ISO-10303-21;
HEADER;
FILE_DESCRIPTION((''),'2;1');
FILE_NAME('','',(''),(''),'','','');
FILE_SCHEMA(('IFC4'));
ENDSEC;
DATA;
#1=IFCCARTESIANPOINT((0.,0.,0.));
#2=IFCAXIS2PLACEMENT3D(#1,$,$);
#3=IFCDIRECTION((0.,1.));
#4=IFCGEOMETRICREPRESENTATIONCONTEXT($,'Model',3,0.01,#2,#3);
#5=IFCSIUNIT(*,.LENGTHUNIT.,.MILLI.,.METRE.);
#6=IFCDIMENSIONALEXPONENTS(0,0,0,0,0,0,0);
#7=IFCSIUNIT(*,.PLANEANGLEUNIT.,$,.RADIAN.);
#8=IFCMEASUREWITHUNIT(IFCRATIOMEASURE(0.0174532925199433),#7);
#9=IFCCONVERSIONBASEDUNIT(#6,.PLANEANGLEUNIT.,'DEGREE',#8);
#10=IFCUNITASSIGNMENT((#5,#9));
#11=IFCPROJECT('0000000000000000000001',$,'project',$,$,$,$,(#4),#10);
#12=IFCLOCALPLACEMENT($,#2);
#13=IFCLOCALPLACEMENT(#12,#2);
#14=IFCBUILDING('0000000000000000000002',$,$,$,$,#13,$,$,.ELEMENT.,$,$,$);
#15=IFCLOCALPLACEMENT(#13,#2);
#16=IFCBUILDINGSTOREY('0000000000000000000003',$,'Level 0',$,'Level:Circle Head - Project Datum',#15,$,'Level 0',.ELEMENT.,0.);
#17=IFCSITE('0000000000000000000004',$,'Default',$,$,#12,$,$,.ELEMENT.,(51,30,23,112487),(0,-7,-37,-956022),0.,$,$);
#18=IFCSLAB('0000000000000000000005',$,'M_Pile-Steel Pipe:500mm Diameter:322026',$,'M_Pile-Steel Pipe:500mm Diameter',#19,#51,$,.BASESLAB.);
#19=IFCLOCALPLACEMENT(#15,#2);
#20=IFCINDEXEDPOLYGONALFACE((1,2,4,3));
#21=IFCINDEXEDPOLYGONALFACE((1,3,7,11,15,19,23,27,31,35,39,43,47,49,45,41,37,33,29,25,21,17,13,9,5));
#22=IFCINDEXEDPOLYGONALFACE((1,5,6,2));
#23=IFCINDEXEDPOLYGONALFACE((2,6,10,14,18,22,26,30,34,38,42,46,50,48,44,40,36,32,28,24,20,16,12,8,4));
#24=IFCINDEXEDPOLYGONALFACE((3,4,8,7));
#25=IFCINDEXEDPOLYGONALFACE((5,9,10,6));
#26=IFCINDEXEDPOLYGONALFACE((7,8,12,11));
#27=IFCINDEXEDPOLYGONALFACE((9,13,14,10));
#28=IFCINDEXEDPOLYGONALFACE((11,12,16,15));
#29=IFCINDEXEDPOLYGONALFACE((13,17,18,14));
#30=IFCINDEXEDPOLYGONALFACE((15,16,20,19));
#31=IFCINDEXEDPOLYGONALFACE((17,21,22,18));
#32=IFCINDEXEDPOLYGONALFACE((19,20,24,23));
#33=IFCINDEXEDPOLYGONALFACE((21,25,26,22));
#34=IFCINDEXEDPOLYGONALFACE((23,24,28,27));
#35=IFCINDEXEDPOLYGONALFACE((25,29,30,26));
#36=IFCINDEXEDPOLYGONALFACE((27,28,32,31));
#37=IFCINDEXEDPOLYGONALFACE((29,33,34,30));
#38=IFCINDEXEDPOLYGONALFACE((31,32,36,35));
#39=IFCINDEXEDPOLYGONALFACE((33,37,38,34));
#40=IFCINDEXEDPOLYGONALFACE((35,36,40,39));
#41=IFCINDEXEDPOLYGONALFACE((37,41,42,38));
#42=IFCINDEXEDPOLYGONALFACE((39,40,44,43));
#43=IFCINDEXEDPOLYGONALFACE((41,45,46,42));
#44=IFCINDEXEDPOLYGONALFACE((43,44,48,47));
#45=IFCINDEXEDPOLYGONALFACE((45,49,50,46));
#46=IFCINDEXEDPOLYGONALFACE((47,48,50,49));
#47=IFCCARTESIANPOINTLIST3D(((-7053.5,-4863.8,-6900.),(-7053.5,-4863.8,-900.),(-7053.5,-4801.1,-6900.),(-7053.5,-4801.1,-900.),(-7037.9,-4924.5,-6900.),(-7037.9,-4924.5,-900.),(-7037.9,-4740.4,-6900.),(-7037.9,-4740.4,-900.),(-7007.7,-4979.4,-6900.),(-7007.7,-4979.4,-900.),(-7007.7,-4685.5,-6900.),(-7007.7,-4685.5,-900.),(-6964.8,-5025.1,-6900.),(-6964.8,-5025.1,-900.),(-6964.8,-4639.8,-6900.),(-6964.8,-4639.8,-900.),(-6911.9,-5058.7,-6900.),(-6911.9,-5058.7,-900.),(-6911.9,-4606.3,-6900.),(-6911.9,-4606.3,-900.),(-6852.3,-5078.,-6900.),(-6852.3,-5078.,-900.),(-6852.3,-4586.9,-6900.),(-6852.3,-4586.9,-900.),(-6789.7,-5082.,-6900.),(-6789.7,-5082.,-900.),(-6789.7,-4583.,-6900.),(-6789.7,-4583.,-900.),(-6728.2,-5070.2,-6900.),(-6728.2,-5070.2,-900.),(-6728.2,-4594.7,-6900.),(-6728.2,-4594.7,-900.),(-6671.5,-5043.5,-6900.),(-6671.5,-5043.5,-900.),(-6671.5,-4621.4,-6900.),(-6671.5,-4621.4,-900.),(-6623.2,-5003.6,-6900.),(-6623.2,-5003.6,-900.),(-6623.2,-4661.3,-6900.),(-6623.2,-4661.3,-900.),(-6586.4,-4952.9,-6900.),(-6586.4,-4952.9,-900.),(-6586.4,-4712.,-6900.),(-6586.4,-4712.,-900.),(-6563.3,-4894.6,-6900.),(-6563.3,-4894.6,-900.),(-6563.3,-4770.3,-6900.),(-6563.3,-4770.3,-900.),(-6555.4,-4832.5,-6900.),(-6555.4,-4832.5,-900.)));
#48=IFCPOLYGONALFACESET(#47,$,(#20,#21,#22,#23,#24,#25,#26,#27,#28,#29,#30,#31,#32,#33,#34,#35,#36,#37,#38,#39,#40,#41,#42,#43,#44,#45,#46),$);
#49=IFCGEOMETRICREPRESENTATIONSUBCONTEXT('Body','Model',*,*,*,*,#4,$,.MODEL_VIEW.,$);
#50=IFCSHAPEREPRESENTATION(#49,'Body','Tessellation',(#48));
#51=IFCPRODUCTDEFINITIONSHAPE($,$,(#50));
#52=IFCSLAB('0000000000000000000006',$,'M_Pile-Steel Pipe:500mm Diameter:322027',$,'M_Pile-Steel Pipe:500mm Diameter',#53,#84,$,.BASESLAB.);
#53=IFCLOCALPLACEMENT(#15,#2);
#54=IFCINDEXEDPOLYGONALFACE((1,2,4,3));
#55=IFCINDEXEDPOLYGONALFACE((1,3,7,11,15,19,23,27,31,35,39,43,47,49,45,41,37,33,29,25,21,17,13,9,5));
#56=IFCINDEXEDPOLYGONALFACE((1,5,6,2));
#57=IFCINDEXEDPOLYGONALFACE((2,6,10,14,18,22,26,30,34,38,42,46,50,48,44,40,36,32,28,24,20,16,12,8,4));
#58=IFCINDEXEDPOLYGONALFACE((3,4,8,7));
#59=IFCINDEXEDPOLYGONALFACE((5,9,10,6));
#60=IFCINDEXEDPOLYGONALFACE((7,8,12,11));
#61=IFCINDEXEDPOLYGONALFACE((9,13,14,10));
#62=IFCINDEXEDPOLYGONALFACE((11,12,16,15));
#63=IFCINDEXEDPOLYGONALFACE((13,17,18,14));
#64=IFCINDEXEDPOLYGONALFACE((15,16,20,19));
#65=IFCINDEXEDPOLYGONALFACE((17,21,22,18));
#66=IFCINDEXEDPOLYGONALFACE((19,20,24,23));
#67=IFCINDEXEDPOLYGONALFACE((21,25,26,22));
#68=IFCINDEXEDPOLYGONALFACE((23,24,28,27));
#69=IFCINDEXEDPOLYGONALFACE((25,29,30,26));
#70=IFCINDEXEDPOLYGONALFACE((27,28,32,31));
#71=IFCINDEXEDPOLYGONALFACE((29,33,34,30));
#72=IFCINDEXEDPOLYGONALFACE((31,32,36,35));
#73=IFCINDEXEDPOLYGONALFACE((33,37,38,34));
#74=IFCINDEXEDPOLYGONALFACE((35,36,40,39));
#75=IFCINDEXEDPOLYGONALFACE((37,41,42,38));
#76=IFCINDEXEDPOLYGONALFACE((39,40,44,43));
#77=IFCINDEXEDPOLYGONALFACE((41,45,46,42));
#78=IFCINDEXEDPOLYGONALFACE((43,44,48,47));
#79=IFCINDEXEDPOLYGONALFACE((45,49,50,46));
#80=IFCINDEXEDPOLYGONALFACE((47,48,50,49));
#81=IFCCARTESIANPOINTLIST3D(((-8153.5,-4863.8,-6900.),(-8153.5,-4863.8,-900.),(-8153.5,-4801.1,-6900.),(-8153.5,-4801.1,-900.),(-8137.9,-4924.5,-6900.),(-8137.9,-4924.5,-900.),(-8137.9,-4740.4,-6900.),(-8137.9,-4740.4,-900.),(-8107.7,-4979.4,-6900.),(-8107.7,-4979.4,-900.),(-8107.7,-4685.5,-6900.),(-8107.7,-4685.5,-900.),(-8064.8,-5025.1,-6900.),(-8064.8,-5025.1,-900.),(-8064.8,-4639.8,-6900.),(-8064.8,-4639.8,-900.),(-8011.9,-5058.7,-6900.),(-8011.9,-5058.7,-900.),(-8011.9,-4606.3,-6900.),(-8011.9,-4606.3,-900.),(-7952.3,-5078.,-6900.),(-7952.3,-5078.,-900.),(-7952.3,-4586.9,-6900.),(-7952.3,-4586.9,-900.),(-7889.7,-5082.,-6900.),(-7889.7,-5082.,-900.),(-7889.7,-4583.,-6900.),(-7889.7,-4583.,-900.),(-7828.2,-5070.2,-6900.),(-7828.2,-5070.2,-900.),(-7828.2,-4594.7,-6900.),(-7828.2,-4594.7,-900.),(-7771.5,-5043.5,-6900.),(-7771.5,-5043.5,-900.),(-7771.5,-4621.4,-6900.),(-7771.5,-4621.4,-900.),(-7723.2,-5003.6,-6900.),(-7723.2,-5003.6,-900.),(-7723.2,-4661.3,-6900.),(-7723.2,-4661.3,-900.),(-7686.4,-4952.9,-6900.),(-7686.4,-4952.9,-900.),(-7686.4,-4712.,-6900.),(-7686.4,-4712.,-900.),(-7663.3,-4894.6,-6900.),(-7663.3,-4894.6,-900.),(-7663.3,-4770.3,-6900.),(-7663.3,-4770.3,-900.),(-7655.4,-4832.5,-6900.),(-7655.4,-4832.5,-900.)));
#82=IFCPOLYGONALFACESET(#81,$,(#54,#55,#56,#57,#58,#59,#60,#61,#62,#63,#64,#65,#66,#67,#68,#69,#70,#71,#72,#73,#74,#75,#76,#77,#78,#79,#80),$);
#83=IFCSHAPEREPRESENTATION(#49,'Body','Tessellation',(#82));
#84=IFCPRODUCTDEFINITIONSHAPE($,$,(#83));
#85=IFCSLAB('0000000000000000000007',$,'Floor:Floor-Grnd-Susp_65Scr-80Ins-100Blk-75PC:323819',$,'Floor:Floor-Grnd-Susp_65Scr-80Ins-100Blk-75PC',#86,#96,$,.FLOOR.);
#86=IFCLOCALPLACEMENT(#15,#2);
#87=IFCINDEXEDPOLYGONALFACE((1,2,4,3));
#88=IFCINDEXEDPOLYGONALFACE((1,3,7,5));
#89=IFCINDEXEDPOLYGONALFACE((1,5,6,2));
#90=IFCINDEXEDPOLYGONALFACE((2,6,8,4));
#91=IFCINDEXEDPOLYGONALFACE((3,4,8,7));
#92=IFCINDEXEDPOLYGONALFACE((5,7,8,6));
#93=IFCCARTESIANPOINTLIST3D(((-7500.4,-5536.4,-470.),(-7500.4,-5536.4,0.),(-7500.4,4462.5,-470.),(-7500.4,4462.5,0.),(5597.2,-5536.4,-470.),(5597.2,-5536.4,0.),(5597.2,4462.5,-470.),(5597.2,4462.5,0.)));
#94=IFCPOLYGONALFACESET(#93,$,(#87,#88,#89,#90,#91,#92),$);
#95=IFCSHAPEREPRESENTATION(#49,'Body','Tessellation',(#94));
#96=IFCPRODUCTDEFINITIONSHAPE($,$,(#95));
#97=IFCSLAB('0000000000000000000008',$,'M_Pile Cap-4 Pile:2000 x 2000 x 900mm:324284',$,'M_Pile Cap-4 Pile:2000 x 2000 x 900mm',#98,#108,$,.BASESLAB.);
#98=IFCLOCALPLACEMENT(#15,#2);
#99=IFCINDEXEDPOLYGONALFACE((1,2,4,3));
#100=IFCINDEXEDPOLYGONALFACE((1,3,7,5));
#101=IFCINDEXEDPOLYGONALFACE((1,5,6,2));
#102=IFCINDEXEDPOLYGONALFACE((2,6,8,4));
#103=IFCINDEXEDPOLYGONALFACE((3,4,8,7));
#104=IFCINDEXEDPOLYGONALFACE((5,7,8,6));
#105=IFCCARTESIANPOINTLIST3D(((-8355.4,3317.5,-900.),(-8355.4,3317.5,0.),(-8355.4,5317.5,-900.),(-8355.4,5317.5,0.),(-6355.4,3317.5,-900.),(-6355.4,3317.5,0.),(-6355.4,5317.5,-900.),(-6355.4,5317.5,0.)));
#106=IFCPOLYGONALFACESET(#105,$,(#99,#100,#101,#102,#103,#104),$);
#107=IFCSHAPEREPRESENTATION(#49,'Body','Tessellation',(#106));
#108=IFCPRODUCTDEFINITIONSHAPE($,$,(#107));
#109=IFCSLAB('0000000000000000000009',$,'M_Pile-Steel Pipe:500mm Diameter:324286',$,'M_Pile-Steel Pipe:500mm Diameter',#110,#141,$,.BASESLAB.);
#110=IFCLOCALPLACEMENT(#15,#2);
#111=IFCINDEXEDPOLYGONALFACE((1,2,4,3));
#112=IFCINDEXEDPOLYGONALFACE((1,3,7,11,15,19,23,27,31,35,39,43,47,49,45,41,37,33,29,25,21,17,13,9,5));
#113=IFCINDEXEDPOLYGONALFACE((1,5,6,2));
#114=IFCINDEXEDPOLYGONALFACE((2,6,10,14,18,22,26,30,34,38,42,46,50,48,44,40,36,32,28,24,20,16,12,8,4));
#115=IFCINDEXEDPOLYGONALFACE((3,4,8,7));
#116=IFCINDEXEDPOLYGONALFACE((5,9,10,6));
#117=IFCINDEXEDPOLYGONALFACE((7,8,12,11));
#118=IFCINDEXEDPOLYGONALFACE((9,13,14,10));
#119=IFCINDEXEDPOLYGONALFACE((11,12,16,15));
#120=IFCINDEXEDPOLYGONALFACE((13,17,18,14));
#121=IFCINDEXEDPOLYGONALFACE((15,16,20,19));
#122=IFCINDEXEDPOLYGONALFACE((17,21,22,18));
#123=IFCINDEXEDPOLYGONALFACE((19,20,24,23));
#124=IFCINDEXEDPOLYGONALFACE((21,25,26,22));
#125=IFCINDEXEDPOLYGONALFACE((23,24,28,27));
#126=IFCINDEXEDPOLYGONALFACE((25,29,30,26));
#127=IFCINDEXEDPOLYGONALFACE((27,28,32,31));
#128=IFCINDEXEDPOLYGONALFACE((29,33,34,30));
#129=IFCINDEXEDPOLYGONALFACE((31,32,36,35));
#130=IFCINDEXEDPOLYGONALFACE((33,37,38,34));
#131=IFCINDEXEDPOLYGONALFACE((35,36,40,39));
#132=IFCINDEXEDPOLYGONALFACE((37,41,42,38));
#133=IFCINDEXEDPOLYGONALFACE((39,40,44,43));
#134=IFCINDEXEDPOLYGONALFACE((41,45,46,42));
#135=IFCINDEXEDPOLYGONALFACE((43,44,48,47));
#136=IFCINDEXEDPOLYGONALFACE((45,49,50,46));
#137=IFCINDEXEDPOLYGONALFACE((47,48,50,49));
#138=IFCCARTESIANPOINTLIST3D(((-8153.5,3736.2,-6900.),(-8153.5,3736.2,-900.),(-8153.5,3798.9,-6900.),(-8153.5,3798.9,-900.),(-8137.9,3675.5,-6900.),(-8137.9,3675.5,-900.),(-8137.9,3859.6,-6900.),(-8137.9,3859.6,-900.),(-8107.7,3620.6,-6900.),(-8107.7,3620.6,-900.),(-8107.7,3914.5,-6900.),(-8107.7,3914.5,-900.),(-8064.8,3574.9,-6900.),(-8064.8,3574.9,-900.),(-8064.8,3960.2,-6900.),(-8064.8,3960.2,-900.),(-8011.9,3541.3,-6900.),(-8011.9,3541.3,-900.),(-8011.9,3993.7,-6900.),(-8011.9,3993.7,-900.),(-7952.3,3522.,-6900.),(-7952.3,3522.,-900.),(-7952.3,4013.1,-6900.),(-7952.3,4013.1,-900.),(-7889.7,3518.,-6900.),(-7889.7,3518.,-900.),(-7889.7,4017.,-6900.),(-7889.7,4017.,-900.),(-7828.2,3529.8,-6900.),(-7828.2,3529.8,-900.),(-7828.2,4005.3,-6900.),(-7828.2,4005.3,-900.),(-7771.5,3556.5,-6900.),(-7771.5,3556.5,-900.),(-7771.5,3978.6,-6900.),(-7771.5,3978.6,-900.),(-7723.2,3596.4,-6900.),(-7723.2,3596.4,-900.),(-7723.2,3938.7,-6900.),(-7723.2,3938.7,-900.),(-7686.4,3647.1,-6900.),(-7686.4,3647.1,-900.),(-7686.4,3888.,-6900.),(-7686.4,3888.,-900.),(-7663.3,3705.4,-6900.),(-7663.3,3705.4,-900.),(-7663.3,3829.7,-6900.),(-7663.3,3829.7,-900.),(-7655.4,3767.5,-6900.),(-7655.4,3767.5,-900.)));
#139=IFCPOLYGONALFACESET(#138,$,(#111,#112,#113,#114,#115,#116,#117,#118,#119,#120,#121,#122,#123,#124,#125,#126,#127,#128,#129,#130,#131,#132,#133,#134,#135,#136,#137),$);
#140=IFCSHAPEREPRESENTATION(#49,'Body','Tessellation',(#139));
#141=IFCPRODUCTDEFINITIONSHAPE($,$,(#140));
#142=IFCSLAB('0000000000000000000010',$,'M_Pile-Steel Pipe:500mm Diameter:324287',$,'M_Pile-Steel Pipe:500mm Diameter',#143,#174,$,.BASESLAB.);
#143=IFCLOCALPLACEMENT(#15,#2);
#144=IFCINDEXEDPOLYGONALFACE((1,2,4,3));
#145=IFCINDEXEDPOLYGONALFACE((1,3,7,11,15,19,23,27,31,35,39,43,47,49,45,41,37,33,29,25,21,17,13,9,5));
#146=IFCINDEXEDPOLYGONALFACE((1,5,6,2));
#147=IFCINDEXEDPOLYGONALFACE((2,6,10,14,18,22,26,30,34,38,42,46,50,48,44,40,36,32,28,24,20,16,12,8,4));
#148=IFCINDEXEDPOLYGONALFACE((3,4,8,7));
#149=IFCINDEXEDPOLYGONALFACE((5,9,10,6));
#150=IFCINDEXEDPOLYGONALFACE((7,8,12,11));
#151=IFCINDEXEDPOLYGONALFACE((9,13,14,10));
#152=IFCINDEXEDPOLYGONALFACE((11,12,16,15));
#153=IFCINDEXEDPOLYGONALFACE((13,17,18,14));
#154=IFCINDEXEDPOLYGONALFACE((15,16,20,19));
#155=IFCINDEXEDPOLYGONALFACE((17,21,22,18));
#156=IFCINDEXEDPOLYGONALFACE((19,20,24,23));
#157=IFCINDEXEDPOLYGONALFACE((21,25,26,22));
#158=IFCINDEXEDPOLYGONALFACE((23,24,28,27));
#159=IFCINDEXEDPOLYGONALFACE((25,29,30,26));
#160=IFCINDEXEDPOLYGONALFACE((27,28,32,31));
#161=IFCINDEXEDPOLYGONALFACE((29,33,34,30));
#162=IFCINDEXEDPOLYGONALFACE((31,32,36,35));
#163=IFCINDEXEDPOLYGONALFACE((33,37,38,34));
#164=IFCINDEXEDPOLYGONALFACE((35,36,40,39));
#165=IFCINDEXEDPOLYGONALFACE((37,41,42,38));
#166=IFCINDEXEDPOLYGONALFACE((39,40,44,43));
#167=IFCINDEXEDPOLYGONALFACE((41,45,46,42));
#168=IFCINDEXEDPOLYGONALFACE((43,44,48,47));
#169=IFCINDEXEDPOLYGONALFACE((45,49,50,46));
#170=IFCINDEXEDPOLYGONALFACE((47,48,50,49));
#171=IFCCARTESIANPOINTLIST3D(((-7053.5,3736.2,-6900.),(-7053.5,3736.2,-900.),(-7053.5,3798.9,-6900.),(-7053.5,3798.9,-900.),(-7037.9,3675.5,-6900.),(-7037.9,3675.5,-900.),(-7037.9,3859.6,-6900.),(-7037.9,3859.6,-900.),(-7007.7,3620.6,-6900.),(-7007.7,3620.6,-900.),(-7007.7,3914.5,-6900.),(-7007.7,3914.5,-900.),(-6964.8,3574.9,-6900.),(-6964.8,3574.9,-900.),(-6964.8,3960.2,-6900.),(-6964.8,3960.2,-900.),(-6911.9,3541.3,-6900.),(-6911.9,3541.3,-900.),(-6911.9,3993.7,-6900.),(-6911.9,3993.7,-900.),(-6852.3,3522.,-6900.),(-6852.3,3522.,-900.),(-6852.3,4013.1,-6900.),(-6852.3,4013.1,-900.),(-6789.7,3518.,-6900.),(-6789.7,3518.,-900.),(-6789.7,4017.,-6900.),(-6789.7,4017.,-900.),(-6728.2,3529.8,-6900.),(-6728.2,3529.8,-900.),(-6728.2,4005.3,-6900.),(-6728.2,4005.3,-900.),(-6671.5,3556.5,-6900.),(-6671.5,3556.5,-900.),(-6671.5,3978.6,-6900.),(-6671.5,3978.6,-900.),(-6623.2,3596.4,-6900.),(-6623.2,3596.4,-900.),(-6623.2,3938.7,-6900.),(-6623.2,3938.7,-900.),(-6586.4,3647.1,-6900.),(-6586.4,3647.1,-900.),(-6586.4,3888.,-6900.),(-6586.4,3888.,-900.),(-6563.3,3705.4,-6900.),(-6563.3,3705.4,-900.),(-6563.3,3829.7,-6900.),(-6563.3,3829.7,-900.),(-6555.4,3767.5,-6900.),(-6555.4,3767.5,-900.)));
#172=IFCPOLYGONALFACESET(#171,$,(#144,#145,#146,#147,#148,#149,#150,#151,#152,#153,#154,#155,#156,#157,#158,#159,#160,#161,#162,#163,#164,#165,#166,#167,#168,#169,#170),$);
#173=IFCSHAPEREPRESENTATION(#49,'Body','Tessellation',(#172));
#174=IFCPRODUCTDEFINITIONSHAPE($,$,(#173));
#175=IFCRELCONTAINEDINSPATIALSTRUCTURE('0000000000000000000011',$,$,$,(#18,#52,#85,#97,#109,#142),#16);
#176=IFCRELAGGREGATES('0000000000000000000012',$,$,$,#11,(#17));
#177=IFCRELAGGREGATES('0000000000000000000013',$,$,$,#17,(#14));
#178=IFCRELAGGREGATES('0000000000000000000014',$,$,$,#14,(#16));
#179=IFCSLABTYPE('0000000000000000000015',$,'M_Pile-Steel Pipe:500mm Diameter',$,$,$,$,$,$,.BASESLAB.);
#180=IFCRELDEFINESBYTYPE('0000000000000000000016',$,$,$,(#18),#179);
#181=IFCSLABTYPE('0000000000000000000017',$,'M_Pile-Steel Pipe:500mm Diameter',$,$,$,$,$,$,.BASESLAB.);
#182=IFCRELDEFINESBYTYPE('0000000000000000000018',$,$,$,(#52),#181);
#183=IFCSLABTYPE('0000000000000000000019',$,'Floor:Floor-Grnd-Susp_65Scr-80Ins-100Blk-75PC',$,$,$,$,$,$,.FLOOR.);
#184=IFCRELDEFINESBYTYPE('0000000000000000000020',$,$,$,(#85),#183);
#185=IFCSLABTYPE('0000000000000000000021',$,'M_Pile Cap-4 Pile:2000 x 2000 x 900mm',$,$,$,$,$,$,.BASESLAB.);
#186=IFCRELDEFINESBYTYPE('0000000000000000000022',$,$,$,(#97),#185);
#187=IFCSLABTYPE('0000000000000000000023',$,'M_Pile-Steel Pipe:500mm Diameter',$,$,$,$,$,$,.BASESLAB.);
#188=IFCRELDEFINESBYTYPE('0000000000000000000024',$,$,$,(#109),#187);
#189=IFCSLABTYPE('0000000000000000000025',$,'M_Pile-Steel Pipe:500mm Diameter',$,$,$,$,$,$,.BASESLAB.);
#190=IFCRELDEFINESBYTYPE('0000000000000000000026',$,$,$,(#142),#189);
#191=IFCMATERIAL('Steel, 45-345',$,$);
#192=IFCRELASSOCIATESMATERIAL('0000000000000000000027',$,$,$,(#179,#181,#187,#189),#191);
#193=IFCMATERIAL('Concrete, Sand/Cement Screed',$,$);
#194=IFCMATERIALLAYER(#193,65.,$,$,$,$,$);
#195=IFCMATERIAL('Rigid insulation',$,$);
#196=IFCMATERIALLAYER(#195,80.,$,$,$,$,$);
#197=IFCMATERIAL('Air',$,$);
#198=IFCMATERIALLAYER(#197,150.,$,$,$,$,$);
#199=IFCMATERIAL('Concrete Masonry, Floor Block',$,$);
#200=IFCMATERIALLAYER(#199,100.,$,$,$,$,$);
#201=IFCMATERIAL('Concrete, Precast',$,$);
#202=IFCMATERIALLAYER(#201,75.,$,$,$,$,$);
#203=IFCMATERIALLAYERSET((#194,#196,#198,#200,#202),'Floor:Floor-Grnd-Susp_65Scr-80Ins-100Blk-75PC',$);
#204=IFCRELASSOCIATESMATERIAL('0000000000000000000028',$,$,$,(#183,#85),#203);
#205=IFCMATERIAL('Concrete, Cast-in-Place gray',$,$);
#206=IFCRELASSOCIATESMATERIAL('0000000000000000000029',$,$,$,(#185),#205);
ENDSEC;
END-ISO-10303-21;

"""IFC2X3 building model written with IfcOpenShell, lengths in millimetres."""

from ifc_helpers import new_model, entity, si_unit, converted_unit, direction, frame, frame_2d, origin, origin_2d_with_axis, place, context, subcontext, project, spatial, rectangle, circle, extrude, material, layer, layer_set, layer_usage, type_object, element, save


model = new_model("IFC2X3")

# Units and contexts
model_context = context("Model", 3, precision=0.01, world=origin(), true_north=direction((0.0, 1.0)))
body_context = subcontext(model_context, "Body", "Model", "MODEL_VIEW")
ifc_project = project(units=[si_unit("LENGTHUNIT", "METRE", prefix="MILLI"), converted_unit("PLANEANGLEUNIT", "DEGREE", entity("IfcRatioMeasure", 0.0174532925199433), si_unit("PLANEANGLEUNIT", "RADIAN"), dimensions=[0, 0, 0, 0, 0, 0, 0])], contexts=[model_context])

# Site, building, storey
site_placement = place(None, origin())
site = spatial("IfcSite", under=ifc_project, at=site_placement, Name="Default", CompositionType="ELEMENT", RefLatitude=(51, 30, 23, 112487), RefLongitude=(0, -7, -37, -956022), RefElevation=0.0)
building_placement = place(site_placement, origin())
building = spatial("IfcBuilding", under=site, at=building_placement, CompositionType="ELEMENT")
storey_placement = place(building_placement, origin())
storey = spatial("IfcBuildingStorey", under=building, at=storey_placement, Name="Level 0", ObjectType="Level:Circle Head - Project Datum", LongName="Level 0", CompositionType="ELEMENT", Elevation=0.0)

# Slabs
ifc_material_1 = material(Name="Concrete, Cast-in-Place gray")
ifc_material_2 = material(Name="Steel, 45-345")
slab_type_1 = type_object("IfcSlabType", Name="M_Pile-Steel Pipe:500mm Diameter", PredefinedType="BASESLAB", material=ifc_material_2)
slab_1_placement = place(storey_placement, origin())
element("IfcSlab", 1, at=slab_1_placement, inside=storey, type_object=slab_type_1, Name="M_Pile-Steel Pipe:500mm Diameter:322026", ObjectType="M_Pile-Steel Pipe:500mm Diameter", PredefinedType="BASESLAB", context=body_context, shape_type="SweptSolid", body=[
    extrude(circle(Radius=250.0, at=frame_2d((0.0, 0.0), x_axis=(1.0, 0.0))), frame((-6805.4, -4832.5, -6900.0)), (0.0, 0.0, 1.0), 6000.0),
])
slab_type_2 = type_object("IfcSlabType", Name="M_Pile-Steel Pipe:500mm Diameter", PredefinedType="BASESLAB", material=ifc_material_2)
slab_2_placement = place(storey_placement, origin())
element("IfcSlab", 2, at=slab_2_placement, inside=storey, type_object=slab_type_2, Name="M_Pile-Steel Pipe:500mm Diameter:322027", ObjectType="M_Pile-Steel Pipe:500mm Diameter", PredefinedType="BASESLAB", context=body_context, shape_type="SweptSolid", body=[
    extrude(circle(Radius=250.0, at=frame_2d((0.0, 0.0), x_axis=(1.0, 0.0))), frame((-7905.4, -4832.5, -6900.0)), (0.0, 0.0, 1.0), 6000.0),
])
ifc_material_3 = material(Name="Concrete, Sand/Cement Screed")
ifc_layer_1 = layer(ifc_material_3, 65.0)
ifc_material_4 = material(Name="Rigid insulation")
ifc_layer_2 = layer(ifc_material_4, 80.0)
ifc_material_5 = material(Name="Air")
ifc_layer_3 = layer(ifc_material_5, 150.0)
ifc_material_6 = material(Name="Concrete Masonry, Floor Block")
ifc_layer_4 = layer(ifc_material_6, 100.0)
ifc_material_7 = material(Name="Concrete, Precast")
ifc_layer_5 = layer(ifc_material_7, 75.0)
ifc_layer_set_1 = layer_set([ifc_layer_1, ifc_layer_2, ifc_layer_3, ifc_layer_4, ifc_layer_5], Name="Floor:Floor-Grnd-Susp_65Scr-80Ins-100Blk-75PC")
ifc_layer_usage_1 = layer_usage(ifc_layer_set_1, "AXIS3", "POSITIVE", 0.0)
slab_type_3 = type_object("IfcSlabType", Name="Floor:Floor-Grnd-Susp_65Scr-80Ins-100Blk-75PC", PredefinedType="FLOOR", material=ifc_layer_set_1)
slab_3_placement = place(storey_placement, origin())
element("IfcSlab", 3, at=slab_3_placement, inside=storey, type_object=slab_type_3, material=ifc_layer_usage_1, Name="Floor:Floor-Grnd-Susp_65Scr-80Ins-100Blk-75PC:323819", ObjectType="Floor:Floor-Grnd-Susp_65Scr-80Ins-100Blk-75PC", PredefinedType="FLOOR", context=body_context, shape_type="SweptSolid", body=[
    extrude(rectangle(XDim=9999.0, YDim=13097.6, at=frame_2d((0.0, 0.0), x_axis=(1.0, 0.0))), frame((-951.6, -536.9, 0.0), z_axis=(0.0, 0.0, -1.0), x_axis=(0.0, 1.0, 0.0)), (0.0, 0.0, 1.0), 470.0),
])
slab_type_4 = type_object("IfcSlabType", Name="M_Pile Cap-4 Pile:2000 x 2000 x 900mm", PredefinedType="BASESLAB", material=ifc_material_1)
slab_4_placement = place(storey_placement, origin())
element("IfcSlab", 4, at=slab_4_placement, inside=storey, type_object=slab_type_4, Name="M_Pile Cap-4 Pile:2000 x 2000 x 900mm:324284", ObjectType="M_Pile Cap-4 Pile:2000 x 2000 x 900mm", PredefinedType="BASESLAB", context=body_context, shape_type="SweptSolid", body=[
    extrude(rectangle(XDim=2000.0, YDim=2000.0, at=frame_2d((0.0, 0.0), x_axis=(1.0, 0.0))), frame((-7355.4, 4317.5, -900.0), z_axis=(0.0, 0.0, 1.0), x_axis=(-1.0, 0.0, 0.0)), (0.0, 0.0, 1.0), 900.0),
])
slab_type_5 = type_object("IfcSlabType", Name="M_Pile-Steel Pipe:500mm Diameter", PredefinedType="BASESLAB", material=ifc_material_2)
slab_5_placement = place(storey_placement, origin())
element("IfcSlab", 5, at=slab_5_placement, inside=storey, type_object=slab_type_5, Name="M_Pile-Steel Pipe:500mm Diameter:324286", ObjectType="M_Pile-Steel Pipe:500mm Diameter", PredefinedType="BASESLAB", context=body_context, shape_type="SweptSolid", body=[
    extrude(circle(Radius=250.0, at=origin_2d_with_axis()), frame((-7905.4, 3767.5, -6900.0)), (0.0, 0.0, 1.0), 6000.0),
])
slab_type_6 = type_object("IfcSlabType", Name="M_Pile-Steel Pipe:500mm Diameter", PredefinedType="BASESLAB", material=ifc_material_2)
slab_6_placement = place(storey_placement, origin())
element("IfcSlab", 6, at=slab_6_placement, inside=storey, type_object=slab_type_6, Name="M_Pile-Steel Pipe:500mm Diameter:324287", ObjectType="M_Pile-Steel Pipe:500mm Diameter", PredefinedType="BASESLAB", context=body_context, shape_type="SweptSolid", body=[
    extrude(circle(Radius=250.0, at=frame_2d((0.0, 0.0), x_axis=(1.0, 0.0))), frame((-6805.4, 3767.5, -6900.0)), (0.0, 0.0, 1.0), 6000.0),
])

save(model, "model.ifc")
